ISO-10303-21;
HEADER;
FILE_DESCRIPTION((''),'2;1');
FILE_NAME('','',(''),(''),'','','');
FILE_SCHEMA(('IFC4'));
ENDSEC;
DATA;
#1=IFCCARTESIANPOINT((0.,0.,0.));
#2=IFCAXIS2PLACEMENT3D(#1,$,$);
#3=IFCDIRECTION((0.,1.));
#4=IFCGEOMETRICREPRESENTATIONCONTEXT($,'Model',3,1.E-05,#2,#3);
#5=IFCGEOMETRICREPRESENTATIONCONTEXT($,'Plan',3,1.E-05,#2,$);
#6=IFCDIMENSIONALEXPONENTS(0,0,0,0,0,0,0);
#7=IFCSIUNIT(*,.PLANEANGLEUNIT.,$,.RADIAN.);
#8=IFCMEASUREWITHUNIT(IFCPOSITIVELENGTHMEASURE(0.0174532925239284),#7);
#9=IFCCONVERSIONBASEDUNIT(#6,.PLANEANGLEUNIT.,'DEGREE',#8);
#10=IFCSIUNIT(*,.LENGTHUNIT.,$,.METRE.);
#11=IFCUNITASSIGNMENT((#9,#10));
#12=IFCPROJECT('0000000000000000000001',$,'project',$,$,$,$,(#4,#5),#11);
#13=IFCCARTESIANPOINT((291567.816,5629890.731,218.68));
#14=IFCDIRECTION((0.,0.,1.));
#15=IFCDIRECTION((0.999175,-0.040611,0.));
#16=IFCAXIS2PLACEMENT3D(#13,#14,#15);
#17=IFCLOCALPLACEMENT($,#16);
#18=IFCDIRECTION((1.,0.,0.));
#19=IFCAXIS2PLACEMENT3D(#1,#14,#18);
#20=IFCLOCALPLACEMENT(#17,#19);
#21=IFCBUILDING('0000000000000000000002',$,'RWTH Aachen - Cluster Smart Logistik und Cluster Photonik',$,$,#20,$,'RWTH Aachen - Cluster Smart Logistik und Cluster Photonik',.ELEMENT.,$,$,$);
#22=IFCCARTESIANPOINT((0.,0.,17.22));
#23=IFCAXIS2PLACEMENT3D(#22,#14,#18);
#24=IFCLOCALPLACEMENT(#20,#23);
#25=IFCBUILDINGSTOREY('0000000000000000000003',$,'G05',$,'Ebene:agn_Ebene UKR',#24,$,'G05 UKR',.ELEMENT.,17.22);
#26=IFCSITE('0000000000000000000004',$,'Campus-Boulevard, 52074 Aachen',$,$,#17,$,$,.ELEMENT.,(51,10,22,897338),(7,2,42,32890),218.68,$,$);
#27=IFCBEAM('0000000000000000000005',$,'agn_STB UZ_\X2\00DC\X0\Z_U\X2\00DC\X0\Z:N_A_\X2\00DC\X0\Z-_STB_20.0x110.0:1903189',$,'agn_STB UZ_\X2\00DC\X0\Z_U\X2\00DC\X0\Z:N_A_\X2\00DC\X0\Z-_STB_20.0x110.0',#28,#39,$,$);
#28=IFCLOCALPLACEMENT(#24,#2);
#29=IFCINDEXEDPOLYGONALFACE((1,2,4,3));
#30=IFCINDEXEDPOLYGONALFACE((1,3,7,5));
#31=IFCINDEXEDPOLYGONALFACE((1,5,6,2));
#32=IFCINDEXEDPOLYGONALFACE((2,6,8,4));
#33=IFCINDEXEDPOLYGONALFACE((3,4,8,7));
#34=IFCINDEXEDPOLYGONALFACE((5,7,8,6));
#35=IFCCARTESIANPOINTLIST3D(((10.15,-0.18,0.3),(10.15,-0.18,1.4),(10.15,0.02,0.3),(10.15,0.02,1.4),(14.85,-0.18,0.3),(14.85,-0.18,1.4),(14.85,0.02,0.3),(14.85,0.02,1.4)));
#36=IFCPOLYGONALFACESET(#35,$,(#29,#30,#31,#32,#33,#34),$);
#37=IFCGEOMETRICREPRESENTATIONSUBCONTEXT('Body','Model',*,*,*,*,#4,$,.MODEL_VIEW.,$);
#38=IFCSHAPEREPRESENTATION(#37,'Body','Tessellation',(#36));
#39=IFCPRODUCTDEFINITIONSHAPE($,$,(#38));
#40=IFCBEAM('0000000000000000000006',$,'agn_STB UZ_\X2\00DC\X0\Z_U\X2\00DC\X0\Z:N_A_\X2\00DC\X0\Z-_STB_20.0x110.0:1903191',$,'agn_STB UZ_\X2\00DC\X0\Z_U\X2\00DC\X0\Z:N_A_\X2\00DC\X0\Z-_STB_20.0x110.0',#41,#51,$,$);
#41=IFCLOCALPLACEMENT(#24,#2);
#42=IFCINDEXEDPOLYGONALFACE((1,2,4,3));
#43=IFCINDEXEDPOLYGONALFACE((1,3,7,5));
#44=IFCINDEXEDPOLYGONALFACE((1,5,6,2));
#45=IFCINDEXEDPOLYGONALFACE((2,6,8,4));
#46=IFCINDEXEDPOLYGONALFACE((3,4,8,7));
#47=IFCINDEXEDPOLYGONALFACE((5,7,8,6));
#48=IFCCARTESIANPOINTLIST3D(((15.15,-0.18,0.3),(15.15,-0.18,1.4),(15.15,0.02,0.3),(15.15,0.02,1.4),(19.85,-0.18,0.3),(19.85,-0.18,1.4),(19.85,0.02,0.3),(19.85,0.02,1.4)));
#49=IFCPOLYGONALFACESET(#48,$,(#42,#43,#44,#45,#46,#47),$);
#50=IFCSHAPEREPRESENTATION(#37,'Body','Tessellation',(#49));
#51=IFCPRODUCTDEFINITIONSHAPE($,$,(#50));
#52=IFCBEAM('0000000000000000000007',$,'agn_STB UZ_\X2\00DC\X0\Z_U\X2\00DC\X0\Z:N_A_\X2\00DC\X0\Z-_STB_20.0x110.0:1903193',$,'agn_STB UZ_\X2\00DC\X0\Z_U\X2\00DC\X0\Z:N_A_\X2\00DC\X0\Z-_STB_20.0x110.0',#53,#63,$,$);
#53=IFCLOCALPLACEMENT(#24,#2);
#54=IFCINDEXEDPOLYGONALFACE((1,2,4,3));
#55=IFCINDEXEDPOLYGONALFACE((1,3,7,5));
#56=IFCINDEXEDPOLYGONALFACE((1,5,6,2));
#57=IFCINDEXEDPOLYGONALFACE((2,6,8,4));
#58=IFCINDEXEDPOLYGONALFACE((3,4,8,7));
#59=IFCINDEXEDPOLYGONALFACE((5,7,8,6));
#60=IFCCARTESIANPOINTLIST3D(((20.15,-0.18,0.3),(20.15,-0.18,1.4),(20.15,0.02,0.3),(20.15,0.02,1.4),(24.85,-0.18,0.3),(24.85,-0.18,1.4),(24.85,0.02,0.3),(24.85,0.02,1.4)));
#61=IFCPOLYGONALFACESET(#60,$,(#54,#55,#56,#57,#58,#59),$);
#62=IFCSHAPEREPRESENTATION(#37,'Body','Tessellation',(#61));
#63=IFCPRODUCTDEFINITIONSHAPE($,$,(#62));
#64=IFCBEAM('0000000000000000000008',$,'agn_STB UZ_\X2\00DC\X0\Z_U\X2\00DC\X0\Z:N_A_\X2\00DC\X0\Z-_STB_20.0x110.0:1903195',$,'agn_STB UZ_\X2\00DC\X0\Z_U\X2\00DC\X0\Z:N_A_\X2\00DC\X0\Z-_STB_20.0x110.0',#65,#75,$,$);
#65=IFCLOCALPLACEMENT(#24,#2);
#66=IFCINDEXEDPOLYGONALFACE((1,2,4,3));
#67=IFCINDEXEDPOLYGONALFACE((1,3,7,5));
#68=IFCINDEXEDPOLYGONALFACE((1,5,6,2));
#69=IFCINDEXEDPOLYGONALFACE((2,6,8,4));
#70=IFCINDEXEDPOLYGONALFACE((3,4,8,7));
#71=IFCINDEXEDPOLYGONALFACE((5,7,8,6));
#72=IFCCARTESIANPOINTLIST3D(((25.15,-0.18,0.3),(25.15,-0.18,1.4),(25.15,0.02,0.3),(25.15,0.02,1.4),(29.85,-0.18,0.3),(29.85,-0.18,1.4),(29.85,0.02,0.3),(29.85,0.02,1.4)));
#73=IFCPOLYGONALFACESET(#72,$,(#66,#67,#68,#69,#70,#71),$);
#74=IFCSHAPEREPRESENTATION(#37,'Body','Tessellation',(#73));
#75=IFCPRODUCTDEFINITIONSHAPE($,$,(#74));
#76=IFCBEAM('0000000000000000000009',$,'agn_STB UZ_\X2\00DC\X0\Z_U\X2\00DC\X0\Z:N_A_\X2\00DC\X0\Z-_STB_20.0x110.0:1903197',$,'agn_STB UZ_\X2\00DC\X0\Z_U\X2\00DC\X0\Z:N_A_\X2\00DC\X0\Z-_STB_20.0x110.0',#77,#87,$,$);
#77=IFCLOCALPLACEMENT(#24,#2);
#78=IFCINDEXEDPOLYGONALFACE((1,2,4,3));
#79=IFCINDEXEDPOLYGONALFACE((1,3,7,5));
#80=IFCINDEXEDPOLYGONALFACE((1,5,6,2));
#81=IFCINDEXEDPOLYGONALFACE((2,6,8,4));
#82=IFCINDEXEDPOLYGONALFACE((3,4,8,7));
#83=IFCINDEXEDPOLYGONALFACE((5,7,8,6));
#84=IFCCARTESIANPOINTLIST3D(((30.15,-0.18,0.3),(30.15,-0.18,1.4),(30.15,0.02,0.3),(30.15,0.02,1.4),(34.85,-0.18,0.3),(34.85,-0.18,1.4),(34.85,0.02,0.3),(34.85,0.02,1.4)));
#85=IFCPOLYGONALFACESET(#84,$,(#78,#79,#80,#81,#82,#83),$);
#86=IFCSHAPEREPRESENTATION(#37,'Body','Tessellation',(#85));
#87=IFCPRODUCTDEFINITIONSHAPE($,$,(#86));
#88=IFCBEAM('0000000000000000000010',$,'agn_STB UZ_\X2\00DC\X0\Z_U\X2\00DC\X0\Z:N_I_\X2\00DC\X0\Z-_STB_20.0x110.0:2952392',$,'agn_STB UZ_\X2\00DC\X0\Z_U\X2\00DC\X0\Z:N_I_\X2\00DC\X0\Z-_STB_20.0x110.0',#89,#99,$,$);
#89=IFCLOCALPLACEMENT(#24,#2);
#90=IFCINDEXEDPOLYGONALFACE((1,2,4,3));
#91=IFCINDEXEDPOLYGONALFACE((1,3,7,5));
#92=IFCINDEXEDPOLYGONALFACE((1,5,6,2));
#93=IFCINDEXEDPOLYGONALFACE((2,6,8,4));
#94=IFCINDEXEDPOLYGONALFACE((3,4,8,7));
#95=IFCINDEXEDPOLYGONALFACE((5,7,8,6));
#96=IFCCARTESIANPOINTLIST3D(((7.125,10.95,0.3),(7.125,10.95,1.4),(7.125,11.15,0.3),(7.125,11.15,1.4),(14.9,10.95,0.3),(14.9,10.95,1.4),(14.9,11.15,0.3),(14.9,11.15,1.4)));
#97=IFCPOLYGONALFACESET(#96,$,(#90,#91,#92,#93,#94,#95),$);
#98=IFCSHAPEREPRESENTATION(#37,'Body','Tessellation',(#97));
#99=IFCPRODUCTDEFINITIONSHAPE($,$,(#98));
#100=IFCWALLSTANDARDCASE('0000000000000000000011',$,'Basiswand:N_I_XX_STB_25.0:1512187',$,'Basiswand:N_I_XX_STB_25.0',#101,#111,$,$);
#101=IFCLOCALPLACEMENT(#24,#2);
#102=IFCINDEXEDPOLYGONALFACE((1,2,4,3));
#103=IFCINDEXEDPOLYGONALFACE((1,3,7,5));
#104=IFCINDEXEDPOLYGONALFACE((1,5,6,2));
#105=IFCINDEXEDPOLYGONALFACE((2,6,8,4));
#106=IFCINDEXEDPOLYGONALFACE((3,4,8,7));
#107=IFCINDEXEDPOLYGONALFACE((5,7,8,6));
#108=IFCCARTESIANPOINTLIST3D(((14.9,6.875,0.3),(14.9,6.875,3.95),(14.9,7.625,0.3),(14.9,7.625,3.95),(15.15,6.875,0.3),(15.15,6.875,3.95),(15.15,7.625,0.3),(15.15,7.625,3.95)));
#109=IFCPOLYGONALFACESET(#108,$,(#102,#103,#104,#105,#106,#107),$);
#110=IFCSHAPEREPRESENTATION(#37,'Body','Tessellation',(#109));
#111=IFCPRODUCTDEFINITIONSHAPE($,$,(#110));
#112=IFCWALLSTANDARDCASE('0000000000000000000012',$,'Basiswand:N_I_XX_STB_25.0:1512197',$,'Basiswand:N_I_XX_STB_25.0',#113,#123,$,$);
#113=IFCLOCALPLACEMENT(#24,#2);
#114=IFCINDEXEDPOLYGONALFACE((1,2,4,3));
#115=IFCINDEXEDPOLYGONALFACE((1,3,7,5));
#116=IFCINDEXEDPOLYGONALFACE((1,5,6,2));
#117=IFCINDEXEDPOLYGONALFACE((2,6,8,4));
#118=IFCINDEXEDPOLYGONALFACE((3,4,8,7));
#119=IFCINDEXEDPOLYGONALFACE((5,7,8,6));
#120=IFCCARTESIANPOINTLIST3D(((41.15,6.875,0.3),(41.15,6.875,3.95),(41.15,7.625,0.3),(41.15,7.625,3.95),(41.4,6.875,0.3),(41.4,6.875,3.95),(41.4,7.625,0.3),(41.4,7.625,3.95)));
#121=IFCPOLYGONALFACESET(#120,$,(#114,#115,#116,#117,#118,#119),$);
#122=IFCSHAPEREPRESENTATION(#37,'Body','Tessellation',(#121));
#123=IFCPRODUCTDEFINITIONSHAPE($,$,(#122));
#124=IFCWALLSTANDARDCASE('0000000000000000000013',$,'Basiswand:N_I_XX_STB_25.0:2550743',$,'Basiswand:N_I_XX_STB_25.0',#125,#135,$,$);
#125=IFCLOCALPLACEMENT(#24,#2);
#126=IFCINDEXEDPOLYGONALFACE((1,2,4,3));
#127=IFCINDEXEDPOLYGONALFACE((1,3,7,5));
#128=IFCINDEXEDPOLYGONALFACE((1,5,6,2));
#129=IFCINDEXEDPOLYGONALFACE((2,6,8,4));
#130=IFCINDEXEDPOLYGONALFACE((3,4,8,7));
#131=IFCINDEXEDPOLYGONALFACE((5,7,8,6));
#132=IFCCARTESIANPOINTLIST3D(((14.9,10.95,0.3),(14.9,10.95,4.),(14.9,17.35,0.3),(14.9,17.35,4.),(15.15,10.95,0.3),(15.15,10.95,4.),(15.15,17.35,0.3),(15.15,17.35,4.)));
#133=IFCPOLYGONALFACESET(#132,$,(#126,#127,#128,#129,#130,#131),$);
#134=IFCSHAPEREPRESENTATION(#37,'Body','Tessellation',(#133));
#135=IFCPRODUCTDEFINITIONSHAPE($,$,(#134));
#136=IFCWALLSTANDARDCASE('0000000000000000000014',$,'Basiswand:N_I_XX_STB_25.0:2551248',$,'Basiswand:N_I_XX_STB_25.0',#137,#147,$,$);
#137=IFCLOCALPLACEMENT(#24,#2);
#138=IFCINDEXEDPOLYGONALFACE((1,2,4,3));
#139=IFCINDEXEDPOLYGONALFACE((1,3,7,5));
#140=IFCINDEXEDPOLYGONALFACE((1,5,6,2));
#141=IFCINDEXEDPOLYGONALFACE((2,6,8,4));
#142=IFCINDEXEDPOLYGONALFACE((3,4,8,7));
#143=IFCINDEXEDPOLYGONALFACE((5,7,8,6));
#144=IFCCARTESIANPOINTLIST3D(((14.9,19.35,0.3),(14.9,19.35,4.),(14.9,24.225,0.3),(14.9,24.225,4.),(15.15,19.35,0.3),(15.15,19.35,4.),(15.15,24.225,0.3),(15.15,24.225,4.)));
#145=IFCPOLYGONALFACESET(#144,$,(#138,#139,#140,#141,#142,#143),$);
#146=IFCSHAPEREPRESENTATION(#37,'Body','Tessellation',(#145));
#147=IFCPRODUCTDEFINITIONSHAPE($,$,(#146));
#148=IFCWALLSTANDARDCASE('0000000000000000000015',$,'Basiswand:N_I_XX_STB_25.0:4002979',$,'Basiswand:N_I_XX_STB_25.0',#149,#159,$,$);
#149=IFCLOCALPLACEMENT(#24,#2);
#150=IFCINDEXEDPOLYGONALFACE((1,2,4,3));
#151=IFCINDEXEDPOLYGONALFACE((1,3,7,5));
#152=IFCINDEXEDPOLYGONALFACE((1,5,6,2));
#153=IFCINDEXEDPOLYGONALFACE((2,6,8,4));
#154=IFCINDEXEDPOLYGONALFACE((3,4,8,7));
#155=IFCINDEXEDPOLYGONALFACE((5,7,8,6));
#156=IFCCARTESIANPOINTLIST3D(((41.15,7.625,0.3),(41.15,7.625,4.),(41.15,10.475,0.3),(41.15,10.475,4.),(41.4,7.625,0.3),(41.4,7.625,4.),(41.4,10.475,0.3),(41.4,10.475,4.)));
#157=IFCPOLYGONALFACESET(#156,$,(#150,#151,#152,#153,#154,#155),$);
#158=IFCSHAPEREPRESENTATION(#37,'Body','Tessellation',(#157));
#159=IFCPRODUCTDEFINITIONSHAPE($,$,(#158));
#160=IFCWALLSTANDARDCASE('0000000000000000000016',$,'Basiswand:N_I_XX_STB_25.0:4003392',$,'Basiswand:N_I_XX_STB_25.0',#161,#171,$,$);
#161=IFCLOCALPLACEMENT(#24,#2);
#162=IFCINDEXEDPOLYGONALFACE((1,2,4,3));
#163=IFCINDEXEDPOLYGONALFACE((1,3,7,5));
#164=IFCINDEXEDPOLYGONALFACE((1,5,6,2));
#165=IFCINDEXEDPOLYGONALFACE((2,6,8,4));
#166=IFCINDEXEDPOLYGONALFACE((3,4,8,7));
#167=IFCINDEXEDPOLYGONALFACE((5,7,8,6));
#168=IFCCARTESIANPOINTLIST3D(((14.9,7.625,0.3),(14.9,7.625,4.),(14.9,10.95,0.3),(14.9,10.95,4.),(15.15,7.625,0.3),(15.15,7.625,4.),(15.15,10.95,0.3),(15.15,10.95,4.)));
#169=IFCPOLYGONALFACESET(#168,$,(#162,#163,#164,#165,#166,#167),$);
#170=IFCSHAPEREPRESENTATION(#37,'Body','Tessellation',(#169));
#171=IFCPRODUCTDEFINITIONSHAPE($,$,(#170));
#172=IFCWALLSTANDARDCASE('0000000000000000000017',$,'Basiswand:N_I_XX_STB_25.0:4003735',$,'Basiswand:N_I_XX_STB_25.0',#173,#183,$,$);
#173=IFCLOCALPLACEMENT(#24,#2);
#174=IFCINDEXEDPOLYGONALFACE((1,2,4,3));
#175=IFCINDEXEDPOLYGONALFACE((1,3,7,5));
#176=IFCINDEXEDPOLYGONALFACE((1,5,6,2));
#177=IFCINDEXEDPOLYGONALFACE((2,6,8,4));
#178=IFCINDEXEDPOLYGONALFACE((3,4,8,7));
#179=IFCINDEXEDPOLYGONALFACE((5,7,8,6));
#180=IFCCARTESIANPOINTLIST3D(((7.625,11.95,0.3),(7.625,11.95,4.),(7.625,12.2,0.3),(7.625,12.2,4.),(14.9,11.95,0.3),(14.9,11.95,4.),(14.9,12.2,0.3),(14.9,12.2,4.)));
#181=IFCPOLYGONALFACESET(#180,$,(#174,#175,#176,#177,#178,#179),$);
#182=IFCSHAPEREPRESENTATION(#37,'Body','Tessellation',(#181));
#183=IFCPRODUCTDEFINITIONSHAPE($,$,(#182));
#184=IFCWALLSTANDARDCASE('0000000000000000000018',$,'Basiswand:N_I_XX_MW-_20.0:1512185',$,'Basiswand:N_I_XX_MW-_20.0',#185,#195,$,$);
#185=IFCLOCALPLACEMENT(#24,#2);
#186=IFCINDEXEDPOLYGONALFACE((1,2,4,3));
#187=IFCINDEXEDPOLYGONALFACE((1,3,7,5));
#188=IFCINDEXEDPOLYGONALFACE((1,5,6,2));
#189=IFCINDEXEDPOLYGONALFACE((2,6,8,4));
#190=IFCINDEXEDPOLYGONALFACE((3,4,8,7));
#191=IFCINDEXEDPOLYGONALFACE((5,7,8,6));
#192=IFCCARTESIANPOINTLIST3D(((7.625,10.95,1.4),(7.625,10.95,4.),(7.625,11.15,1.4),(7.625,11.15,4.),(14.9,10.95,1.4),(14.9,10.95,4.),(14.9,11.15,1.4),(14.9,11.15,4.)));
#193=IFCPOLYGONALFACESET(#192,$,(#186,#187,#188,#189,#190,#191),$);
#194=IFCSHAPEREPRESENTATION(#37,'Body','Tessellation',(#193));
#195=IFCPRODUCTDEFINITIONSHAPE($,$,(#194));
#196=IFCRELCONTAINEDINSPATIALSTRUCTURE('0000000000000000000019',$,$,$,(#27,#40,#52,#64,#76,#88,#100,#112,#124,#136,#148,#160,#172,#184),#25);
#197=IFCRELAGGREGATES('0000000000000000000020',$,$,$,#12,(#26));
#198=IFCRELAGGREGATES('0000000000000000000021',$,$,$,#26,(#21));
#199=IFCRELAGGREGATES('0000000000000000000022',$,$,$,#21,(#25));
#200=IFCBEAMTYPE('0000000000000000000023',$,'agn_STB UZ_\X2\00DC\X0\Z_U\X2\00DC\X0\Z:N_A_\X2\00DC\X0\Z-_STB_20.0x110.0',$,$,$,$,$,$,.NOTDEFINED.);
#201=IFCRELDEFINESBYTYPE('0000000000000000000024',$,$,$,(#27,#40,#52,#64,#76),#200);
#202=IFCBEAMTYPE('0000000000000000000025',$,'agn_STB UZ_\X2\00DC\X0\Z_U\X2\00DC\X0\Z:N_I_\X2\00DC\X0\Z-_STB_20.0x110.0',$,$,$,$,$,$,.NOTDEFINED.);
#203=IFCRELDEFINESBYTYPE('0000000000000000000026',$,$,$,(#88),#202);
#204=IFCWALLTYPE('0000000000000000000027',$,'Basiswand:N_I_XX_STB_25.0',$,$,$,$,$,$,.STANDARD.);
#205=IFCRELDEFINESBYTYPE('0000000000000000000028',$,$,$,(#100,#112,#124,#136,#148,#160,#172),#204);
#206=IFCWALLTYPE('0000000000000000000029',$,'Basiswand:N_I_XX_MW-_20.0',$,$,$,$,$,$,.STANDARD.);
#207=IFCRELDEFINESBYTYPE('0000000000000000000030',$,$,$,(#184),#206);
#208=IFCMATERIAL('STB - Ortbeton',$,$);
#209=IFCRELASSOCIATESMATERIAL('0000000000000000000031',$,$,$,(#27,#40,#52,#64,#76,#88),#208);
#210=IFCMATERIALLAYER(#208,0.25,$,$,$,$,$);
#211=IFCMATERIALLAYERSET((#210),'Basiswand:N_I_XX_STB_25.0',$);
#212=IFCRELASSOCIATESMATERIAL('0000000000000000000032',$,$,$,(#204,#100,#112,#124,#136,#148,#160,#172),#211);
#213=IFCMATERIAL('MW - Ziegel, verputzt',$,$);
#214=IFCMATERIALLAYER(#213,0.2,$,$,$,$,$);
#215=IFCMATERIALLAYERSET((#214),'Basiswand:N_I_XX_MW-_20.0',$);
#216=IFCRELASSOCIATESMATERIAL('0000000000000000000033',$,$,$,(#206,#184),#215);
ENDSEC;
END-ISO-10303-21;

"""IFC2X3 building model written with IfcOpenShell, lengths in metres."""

from ifc_helpers import new_model, entity, si_unit, converted_unit, direction, frame, frame_2d, origin, origin_with_axes, place, context, subcontext, project, spatial, rectangle, extrude, material, layer, layer_set, layer_usage, type_object, element, save


model = new_model("IFC2X3")

# Units and contexts
model_context = context("Model", 3, precision=1e-05, world=origin(), true_north=direction((0.0, 1.0)))
plan_context = context("Plan", 3, precision=1e-05, world=origin())
body_context = subcontext(model_context, "Body", "Model", "MODEL_VIEW")
ifc_project = project(units=[converted_unit("PLANEANGLEUNIT", "DEGREE", entity("IfcPositiveLengthMeasure", 0.0174532925239284), si_unit("PLANEANGLEUNIT", "RADIAN"), dimensions=[0, 0, 0, 0, 0, 0, 0]), si_unit("LENGTHUNIT", "METRE")], contexts=[model_context, plan_context])

# Site, building, storey
site_placement = place(None, frame((291567.816, 5629890.731, 218.68), z_axis=(0.0, 0.0, 1.0), x_axis=(0.999175, -0.040611, 0.0)))
site = spatial("IfcSite", under=ifc_project, at=site_placement, Name="Campus-Boulevard, 52074 Aachen", CompositionType="ELEMENT", RefLatitude=(51, 10, 22, 897338), RefLongitude=(7, 2, 42, 32890), RefElevation=218.68)
building_placement = place(site_placement, origin_with_axes())
building = spatial("IfcBuilding", under=site, at=building_placement, Name="RWTH Aachen - Cluster Smart Logistik und Cluster Photonik", LongName="RWTH Aachen - Cluster Smart Logistik und Cluster Photonik", CompositionType="ELEMENT")
storey_placement = place(building_placement, frame((0.0, 0.0, 17.22), z_axis=(0.0, 0.0, 1.0), x_axis=(1.0, 0.0, 0.0)))
storey = spatial("IfcBuildingStorey", under=building, at=storey_placement, Name="G05", ObjectType="Ebene:agn_Ebene UKR", LongName="G05 UKR", CompositionType="ELEMENT", Elevation=17.22)

# Beams
ifc_material_1 = material(Name="STB - Ortbeton")
beam_type_1 = type_object("IfcBeamType", Name="agn_STB UZ_ÜZ_UÜZ:N_A_ÜZ-_STB_20.0x110.0", PredefinedType="NOTDEFINED")
for number, where, z_axis, x_axis, name in (
    (1, (10.15, -0.08, 0.3), (0.0, 0.0, 1.0), (1.0, 0.0, 0.0), "agn_STB UZ_ÜZ_UÜZ:N_A_ÜZ-_STB_20.0x110.0:1903189"),
    (2, (15.15, -0.08, 0.3), (0.0, 0.0, 1.0), (1.0, 0.0, 0.0), "agn_STB UZ_ÜZ_UÜZ:N_A_ÜZ-_STB_20.0x110.0:1903191"),
    (3, (20.15, -0.08, 0.3), (0.0, 0.0, 1.0), (1.0, 0.0, 0.0), "agn_STB UZ_ÜZ_UÜZ:N_A_ÜZ-_STB_20.0x110.0:1903193"),
    (4, (25.15, -0.08, 0.3), (0.0, 0.0, 1.0), (1.0, 0.0, 0.0), "agn_STB UZ_ÜZ_UÜZ:N_A_ÜZ-_STB_20.0x110.0:1903195"),
    (5, (30.15, -0.08, 0.3), (0.0, 0.0, 1.0), (1.0, 0.0, 0.0), "agn_STB UZ_ÜZ_UÜZ:N_A_ÜZ-_STB_20.0x110.0:1903197"),
):
    element("IfcBeam", number, at=place(storey_placement, frame(where, z_axis=z_axis, x_axis=x_axis)), inside=storey, type_object=beam_type_1, material=ifc_material_1, Name=name, ObjectType="agn_STB UZ_ÜZ_UÜZ:N_A_ÜZ-_STB_20.0x110.0", context=body_context, shape_type="SweptSolid", body=[
        extrude(rectangle(XDim=1.1, YDim=0.2, at=frame_2d((0.0, 0.0), x_axis=(1.0, 0.0))), frame((0.0, 0.0, 0.55), z_axis=(1.0, 0.0, 0.0), x_axis=(0.0, 0.0, -1.0)), (0.0, 0.0, 1.0), 4.7),
    ])
beam_type_2 = type_object("IfcBeamType", Name="agn_STB UZ_ÜZ_UÜZ:N_I_ÜZ-_STB_20.0x110.0", PredefinedType="NOTDEFINED")
beam_1_placement = place(storey_placement, frame((15.025, 11.05, 0.3), z_axis=(0.0, 0.0, 1.0), x_axis=(-1.0, 0.0, 0.0)))
element("IfcBeam", 6, at=beam_1_placement, inside=storey, type_object=beam_type_2, material=ifc_material_1, Name="agn_STB UZ_ÜZ_UÜZ:N_I_ÜZ-_STB_20.0x110.0:2952392", ObjectType="agn_STB UZ_ÜZ_UÜZ:N_I_ÜZ-_STB_20.0x110.0", context=body_context, shape_type="SweptSolid", body=[
    extrude(rectangle(XDim=1.1, YDim=0.2, at=frame_2d((0.0, 0.0), x_axis=(1.0, 0.0))), frame((0.125, 0.0, 0.55), z_axis=(1.0, 0.0, 0.0), x_axis=(0.0, 0.0, -1.0)), (0.0, 0.0, 1.0), 7.775),
])

# Walls
ifc_layer_1 = layer(ifc_material_1, 0.25)
ifc_layer_set_1 = layer_set([ifc_layer_1], Name="Basiswand:N_I_XX_STB_25.0")
ifc_layer_usage_1 = layer_usage(ifc_layer_set_1, "AXIS2", "NEGATIVE", 0.125)
wall_type_1 = type_object("IfcWallType", Name="Basiswand:N_I_XX_STB_25.0", PredefinedType="STANDARD", material=ifc_layer_set_1)
wall_1_placement = place(storey_placement, frame((15.025, 6.875, 0.3), z_axis=(0.0, 0.0, 1.0), x_axis=(0.0, 1.0, 0.0)))
element("IfcWallStandardCase", 7, at=wall_1_placement, inside=storey, type_object=wall_type_1, material=ifc_layer_usage_1, Name="Basiswand:N_I_XX_STB_25.0:1512187", ObjectType="Basiswand:N_I_XX_STB_25.0", context=body_context, shape_type="SweptSolid", body=[
    extrude(rectangle(XDim=0.75, YDim=0.25, at=frame_2d((0.375, 0.0), x_axis=(-1.0, 0.0))), origin(), (0.0, 0.0, 1.0), 3.65),
])
ifc_layer_usage_2 = layer_usage(ifc_layer_set_1, "AXIS2", "NEGATIVE", 0.125)
wall_2_placement = place(storey_placement, frame((41.275, 6.875, 0.3), z_axis=(0.0, 0.0, 1.0), x_axis=(0.0, 1.0, 0.0)))
element("IfcWallStandardCase", 8, at=wall_2_placement, inside=storey, type_object=wall_type_1, material=ifc_layer_usage_2, Name="Basiswand:N_I_XX_STB_25.0:1512197", ObjectType="Basiswand:N_I_XX_STB_25.0", context=body_context, shape_type="SweptSolid", body=[
    extrude(rectangle(XDim=0.75, YDim=0.25, at=frame_2d((0.375, 0.0), x_axis=(-1.0, 0.0))), origin(), (0.0, 0.0, 1.0), 3.65),
])
ifc_layer_usage_3 = layer_usage(ifc_layer_set_1, "AXIS2", "NEGATIVE", 0.125)
wall_3_placement = place(storey_placement, frame((15.025, 10.95, 0.3), z_axis=(0.0, 0.0, 1.0), x_axis=(0.0, 1.0, 0.0)))
element("IfcWallStandardCase", 9, at=wall_3_placement, inside=storey, type_object=wall_type_1, material=ifc_layer_usage_3, Name="Basiswand:N_I_XX_STB_25.0:2550743", ObjectType="Basiswand:N_I_XX_STB_25.0", context=body_context, shape_type="SweptSolid", body=[
    extrude(rectangle(XDim=6.4, YDim=0.25, at=frame_2d((3.2, 0.0), x_axis=(-1.0, 0.0))), origin(), (0.0, 0.0, 1.0), 3.7),
])
ifc_layer_usage_4 = layer_usage(ifc_layer_set_1, "AXIS2", "NEGATIVE", 0.125)
wall_4_placement = place(storey_placement, frame((15.025, 19.35, 0.3), z_axis=(0.0, 0.0, 1.0), x_axis=(0.0, 1.0, 0.0)))
element("IfcWallStandardCase", 10, at=wall_4_placement, inside=storey, type_object=wall_type_1, material=ifc_layer_usage_4, Name="Basiswand:N_I_XX_STB_25.0:2551248", ObjectType="Basiswand:N_I_XX_STB_25.0", context=body_context, shape_type="SweptSolid", body=[
    extrude(rectangle(XDim=4.875, YDim=0.25, at=frame_2d((2.4375, 0.0), x_axis=(-1.0, 0.0))), origin(), (0.0, 0.0, 1.0), 3.7),
])
ifc_layer_usage_5 = layer_usage(ifc_layer_set_1, "AXIS2", "NEGATIVE", 0.125)
wall_5_placement = place(storey_placement, frame((41.275, 7.625, 0.3), z_axis=(0.0, 0.0, 1.0), x_axis=(0.0, 1.0, 0.0)))
element("IfcWallStandardCase", 11, at=wall_5_placement, inside=storey, type_object=wall_type_1, material=ifc_layer_usage_5, Name="Basiswand:N_I_XX_STB_25.0:4002979", ObjectType="Basiswand:N_I_XX_STB_25.0", context=body_context, shape_type="SweptSolid", body=[
    extrude(rectangle(XDim=2.85, YDim=0.25, at=frame_2d((1.425, 0.0), x_axis=(-1.0, 0.0))), origin(), (0.0, 0.0, 1.0), 3.7),
])
ifc_layer_usage_6 = layer_usage(ifc_layer_set_1, "AXIS2", "NEGATIVE", 0.125)
wall_6_placement = place(storey_placement, frame((15.025, 7.625, 0.3), z_axis=(0.0, 0.0, 1.0), x_axis=(0.0, 1.0, 0.0)))
element("IfcWallStandardCase", 12, at=wall_6_placement, inside=storey, type_object=wall_type_1, material=ifc_layer_usage_6, Name="Basiswand:N_I_XX_STB_25.0:4003392", ObjectType="Basiswand:N_I_XX_STB_25.0", context=body_context, shape_type="SweptSolid", body=[
    extrude(rectangle(XDim=3.325, YDim=0.25, at=frame_2d((1.6625, 0.0), x_axis=(-1.0, 0.0))), origin(), (0.0, 0.0, 1.0), 3.7),
])
ifc_layer_usage_7 = layer_usage(ifc_layer_set_1, "AXIS2", "NEGATIVE", 0.125)
wall_7_placement = place(storey_placement, frame((7.625, 12.075, 0.3), z_axis=(0.0, 0.0, 1.0), x_axis=(1.0, 0.0, 0.0)))
element("IfcWallStandardCase", 13, at=wall_7_placement, inside=storey, type_object=wall_type_1, material=ifc_layer_usage_7, Name="Basiswand:N_I_XX_STB_25.0:4003735", ObjectType="Basiswand:N_I_XX_STB_25.0", context=body_context, shape_type="SweptSolid", body=[
    extrude(rectangle(XDim=7.275, YDim=0.25, at=frame_2d((3.6375, 0.0), x_axis=(-1.0, 0.0))), origin(), (0.0, 0.0, 1.0), 3.7),
])
ifc_material_2 = material(Name="MW - Ziegel, verputzt")
ifc_layer_2 = layer(ifc_material_2, 0.2)
ifc_layer_set_2 = layer_set([ifc_layer_2], Name="Basiswand:N_I_XX_MW-_20.0")
ifc_layer_usage_8 = layer_usage(ifc_layer_set_2, "AXIS2", "NEGATIVE", 0.1)
wall_type_2 = type_object("IfcWallType", Name="Basiswand:N_I_XX_MW-_20.0", PredefinedType="STANDARD", material=ifc_layer_set_2)
wall_8_placement = place(storey_placement, frame((14.9, 11.05, 1.4), z_axis=(0.0, 0.0, 1.0), x_axis=(-1.0, 0.0, 0.0)))
element("IfcWallStandardCase", 14, at=wall_8_placement, inside=storey, type_object=wall_type_2, material=ifc_layer_usage_8, Name="Basiswand:N_I_XX_MW-_20.0:1512185", ObjectType="Basiswand:N_I_XX_MW-_20.0", context=body_context, shape_type="SweptSolid", body=[
    extrude(rectangle(XDim=7.275, YDim=0.2, at=frame_2d((3.6375, 0.0), x_axis=(-1.0, 0.0))), origin(), (0.0, 0.0, 1.0), 2.6),
])

save(model, "model.ifc")
